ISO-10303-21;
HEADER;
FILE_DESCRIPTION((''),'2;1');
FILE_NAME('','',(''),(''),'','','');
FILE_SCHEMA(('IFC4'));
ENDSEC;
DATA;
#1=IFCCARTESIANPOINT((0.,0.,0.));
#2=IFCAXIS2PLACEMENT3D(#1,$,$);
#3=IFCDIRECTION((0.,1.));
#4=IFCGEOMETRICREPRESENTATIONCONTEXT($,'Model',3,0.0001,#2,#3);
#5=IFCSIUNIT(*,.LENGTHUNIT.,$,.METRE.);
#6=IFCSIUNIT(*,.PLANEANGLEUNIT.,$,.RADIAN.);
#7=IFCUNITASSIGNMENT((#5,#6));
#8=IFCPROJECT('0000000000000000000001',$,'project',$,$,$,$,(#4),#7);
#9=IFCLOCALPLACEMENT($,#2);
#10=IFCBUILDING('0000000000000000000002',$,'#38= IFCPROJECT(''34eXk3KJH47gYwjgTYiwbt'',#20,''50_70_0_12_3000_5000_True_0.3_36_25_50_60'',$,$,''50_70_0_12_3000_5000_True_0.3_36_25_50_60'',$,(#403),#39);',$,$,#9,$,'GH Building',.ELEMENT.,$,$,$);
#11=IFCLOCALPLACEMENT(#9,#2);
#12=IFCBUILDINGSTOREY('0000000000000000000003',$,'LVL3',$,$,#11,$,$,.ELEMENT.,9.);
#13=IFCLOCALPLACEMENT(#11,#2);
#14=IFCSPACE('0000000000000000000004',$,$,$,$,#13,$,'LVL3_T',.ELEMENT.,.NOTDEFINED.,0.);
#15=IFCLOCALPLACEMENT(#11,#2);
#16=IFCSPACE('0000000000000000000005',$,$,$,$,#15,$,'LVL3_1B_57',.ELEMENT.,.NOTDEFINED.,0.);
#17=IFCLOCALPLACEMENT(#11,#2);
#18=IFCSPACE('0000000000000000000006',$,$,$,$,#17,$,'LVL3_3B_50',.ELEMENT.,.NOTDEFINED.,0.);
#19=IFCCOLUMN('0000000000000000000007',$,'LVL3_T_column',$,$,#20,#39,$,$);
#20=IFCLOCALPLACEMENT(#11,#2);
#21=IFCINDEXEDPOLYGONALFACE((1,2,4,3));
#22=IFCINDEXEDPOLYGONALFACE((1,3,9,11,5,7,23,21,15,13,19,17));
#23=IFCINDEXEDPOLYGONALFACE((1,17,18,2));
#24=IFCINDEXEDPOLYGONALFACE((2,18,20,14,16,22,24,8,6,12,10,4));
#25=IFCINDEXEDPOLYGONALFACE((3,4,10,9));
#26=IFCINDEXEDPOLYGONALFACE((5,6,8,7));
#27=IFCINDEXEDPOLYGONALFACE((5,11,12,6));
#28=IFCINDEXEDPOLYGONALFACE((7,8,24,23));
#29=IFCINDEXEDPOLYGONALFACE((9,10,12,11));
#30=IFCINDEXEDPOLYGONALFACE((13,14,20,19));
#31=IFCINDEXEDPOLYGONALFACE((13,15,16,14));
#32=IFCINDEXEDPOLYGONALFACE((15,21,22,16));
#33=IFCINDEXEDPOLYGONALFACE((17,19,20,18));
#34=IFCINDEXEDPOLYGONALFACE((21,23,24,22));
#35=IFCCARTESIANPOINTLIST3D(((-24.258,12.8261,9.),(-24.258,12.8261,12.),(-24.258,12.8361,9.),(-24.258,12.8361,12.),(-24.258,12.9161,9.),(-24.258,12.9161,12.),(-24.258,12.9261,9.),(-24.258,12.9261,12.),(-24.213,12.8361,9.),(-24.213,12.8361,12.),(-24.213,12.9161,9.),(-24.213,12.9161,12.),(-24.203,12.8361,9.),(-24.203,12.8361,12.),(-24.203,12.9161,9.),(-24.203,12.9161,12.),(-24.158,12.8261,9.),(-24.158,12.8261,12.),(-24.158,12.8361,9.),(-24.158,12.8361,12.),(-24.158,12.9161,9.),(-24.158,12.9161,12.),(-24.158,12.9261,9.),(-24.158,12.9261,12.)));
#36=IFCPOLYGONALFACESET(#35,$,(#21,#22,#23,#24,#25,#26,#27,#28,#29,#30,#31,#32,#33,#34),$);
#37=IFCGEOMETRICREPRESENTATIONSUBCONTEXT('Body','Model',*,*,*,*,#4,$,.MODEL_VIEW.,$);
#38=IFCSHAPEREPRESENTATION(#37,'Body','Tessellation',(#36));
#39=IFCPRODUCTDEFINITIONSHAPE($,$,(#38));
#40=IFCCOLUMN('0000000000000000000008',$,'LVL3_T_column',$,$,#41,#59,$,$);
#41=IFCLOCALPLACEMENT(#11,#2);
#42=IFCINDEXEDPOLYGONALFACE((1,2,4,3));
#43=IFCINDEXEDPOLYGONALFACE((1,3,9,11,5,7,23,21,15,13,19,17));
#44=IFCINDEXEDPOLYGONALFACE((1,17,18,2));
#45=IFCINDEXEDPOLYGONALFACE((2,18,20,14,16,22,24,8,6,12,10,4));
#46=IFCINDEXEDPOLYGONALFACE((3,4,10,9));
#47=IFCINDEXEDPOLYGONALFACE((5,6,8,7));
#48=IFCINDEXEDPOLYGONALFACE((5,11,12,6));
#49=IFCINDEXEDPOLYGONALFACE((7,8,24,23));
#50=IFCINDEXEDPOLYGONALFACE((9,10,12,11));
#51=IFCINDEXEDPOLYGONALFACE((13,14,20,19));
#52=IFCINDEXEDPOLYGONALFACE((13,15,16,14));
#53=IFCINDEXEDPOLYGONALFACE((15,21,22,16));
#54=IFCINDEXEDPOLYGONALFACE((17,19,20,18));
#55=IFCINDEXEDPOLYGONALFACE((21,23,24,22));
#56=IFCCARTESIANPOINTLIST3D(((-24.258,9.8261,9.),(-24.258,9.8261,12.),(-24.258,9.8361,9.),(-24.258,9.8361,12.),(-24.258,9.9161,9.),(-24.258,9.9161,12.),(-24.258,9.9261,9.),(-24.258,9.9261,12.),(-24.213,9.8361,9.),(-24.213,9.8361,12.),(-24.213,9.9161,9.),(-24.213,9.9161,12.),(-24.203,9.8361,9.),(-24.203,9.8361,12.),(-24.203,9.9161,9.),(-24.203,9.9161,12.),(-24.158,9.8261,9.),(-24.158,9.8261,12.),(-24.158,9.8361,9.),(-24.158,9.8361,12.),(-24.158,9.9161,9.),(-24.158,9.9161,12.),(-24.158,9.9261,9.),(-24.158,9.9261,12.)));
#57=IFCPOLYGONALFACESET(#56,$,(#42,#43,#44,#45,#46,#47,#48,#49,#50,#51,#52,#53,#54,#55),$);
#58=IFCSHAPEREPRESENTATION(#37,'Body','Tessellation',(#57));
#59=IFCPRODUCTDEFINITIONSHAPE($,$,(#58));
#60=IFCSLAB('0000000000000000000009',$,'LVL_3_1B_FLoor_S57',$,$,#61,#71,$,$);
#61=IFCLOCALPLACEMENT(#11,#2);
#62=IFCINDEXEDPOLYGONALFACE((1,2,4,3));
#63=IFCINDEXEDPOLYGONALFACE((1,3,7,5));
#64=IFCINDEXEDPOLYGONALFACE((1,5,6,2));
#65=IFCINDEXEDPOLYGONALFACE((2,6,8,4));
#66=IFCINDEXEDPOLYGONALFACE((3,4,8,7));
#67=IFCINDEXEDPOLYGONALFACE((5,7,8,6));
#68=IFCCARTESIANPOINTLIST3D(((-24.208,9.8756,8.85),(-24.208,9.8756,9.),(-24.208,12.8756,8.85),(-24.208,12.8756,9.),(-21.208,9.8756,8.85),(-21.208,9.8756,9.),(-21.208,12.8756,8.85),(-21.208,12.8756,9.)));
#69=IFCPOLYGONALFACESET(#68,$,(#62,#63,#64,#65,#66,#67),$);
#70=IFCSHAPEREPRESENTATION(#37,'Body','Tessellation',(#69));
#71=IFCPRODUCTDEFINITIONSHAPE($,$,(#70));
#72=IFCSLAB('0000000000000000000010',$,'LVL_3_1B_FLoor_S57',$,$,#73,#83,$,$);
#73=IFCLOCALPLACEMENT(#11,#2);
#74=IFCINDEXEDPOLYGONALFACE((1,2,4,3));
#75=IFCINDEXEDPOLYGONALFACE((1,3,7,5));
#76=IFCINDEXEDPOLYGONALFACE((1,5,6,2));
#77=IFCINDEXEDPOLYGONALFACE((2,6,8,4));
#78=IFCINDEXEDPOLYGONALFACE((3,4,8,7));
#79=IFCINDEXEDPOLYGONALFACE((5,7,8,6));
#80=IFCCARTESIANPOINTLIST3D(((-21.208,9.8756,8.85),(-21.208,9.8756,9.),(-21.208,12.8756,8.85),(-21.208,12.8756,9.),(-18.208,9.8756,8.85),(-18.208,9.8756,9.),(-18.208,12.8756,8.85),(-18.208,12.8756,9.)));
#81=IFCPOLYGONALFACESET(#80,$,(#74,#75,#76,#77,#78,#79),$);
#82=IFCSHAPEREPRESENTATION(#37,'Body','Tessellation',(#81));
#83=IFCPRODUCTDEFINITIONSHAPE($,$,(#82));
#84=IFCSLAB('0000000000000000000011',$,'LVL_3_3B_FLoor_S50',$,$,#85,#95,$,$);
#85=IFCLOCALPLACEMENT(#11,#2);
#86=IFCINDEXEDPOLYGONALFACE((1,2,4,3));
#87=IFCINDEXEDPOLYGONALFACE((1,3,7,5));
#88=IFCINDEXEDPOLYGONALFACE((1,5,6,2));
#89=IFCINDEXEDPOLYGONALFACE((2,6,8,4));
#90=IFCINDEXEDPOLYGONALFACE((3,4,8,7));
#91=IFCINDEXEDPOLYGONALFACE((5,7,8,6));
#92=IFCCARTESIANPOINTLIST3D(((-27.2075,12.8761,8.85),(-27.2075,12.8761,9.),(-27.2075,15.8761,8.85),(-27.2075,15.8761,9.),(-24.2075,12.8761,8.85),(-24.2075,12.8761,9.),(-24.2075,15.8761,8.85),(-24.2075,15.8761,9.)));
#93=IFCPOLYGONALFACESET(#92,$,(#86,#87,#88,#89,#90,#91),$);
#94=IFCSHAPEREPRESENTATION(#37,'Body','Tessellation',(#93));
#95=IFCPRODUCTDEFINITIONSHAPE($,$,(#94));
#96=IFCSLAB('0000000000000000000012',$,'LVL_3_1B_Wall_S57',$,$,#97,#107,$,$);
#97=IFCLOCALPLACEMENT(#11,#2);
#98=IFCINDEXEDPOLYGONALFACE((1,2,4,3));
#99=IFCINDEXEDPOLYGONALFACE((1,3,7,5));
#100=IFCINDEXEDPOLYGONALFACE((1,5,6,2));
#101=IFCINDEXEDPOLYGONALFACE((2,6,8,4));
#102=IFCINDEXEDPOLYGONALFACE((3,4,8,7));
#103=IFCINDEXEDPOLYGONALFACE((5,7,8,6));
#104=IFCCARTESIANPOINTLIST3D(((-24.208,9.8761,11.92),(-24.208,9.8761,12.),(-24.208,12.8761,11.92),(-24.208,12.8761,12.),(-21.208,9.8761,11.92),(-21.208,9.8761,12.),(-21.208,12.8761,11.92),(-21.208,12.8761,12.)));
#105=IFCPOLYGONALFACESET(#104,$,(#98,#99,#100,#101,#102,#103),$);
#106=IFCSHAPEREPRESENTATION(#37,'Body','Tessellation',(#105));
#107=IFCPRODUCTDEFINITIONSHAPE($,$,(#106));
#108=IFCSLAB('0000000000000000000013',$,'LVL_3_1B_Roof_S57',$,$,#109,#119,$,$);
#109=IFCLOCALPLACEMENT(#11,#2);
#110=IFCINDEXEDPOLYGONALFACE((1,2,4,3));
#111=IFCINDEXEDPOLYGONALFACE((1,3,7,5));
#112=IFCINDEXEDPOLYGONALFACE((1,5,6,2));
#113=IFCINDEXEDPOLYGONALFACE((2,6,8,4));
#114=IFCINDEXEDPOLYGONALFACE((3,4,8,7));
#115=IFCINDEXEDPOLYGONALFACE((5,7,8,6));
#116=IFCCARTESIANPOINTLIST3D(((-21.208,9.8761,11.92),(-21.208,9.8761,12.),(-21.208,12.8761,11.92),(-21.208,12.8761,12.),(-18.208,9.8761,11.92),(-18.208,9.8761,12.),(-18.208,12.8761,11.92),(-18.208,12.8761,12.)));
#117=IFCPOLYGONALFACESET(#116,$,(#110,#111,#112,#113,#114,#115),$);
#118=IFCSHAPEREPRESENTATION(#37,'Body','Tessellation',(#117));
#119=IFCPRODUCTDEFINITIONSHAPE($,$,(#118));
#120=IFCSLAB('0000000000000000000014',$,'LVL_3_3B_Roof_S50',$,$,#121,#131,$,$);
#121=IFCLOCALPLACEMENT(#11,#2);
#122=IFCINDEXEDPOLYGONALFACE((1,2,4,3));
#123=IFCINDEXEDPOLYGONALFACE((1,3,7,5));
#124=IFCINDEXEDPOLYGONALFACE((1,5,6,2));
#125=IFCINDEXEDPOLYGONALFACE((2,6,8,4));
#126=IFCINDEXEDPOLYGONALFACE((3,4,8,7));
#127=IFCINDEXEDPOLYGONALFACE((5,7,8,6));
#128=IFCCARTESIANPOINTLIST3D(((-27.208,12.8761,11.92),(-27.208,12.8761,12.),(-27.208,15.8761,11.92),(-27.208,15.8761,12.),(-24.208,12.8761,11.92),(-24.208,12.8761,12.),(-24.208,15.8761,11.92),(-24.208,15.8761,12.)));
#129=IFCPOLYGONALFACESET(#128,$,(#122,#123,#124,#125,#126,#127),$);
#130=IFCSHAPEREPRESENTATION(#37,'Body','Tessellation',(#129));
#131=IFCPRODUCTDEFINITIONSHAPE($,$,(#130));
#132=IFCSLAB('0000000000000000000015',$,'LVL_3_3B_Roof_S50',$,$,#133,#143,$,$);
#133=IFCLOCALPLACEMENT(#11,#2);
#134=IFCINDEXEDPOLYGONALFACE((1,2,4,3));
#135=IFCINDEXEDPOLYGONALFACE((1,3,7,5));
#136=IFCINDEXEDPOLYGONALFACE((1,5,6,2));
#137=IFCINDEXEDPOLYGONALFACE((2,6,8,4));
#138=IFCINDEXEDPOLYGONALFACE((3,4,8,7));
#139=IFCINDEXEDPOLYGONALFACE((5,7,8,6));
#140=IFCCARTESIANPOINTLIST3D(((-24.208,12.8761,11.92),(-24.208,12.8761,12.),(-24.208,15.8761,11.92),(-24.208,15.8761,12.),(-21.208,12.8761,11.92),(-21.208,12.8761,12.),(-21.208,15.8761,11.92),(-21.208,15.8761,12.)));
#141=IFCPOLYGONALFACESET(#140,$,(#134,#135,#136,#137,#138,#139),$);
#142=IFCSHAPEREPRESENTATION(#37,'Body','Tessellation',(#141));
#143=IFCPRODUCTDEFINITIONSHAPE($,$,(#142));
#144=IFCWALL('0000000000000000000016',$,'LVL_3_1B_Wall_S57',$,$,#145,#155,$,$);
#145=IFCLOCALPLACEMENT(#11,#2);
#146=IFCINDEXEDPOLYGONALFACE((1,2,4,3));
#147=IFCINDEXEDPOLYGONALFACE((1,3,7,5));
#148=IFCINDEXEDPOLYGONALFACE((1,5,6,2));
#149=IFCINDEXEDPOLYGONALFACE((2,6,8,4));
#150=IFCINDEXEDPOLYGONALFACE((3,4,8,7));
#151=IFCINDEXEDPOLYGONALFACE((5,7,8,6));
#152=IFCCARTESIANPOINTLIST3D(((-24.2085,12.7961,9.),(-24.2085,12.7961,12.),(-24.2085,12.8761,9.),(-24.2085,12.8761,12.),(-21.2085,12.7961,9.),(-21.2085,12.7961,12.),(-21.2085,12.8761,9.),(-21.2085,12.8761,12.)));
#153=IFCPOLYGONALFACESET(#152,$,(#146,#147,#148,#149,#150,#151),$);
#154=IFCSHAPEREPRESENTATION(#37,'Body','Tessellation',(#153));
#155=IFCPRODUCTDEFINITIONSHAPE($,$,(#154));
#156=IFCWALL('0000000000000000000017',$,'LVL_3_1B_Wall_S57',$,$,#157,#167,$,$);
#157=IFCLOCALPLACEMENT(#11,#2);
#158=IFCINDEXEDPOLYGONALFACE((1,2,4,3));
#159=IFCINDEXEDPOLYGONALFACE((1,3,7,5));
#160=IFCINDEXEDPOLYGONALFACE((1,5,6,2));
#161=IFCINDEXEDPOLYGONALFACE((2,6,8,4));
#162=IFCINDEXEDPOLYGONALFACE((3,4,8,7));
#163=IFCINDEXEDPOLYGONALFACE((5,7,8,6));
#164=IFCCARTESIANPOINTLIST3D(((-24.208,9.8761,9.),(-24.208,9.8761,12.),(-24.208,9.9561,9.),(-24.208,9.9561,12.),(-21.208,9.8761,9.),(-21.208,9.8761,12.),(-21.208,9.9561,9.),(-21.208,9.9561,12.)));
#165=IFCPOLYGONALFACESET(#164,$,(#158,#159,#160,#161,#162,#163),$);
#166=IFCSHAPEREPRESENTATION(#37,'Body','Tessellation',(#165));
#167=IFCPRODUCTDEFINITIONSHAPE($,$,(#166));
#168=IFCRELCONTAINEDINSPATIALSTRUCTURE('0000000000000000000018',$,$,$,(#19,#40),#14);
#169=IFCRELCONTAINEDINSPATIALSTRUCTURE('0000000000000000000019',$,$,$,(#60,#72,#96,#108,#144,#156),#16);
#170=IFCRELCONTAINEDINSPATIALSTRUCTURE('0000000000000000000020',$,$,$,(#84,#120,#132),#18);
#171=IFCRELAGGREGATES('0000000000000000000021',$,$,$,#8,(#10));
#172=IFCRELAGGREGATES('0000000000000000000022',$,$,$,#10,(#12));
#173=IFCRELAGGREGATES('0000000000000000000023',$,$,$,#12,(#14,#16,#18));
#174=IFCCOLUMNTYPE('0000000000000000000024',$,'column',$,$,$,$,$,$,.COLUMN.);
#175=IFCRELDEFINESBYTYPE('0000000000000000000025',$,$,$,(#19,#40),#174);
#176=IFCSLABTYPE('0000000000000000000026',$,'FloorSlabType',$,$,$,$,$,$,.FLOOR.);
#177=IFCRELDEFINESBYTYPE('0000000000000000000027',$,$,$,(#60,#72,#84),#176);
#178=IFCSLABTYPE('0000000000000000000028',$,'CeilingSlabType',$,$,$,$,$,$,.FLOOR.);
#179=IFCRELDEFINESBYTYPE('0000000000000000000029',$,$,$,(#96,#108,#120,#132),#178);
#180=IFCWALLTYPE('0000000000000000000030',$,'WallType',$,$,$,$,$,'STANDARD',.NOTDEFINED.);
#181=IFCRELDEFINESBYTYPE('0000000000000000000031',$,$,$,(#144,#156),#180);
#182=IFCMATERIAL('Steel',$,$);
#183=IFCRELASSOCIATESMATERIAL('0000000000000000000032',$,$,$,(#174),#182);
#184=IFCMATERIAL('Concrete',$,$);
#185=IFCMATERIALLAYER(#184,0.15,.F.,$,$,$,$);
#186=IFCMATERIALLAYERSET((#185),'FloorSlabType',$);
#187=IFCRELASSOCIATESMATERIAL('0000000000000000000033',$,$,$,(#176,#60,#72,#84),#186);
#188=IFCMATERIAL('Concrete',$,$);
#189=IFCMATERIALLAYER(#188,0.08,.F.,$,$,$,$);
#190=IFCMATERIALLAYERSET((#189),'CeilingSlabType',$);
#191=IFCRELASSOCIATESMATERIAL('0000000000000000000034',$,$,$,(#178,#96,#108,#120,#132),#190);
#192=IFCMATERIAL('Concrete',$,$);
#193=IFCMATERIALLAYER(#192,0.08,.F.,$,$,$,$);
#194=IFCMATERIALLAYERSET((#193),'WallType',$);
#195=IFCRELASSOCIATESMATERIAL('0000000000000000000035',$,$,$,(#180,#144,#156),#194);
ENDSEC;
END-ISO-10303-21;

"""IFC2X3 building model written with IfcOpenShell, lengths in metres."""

from ifc_helpers import new_model, si_unit, direction, frame, frame_2d, origin, origin_2d, place, context, subcontext, project, spatial, rectangle, i_section, extrude, material, layer, layer_set, layer_usage, type_object, element, save


model = new_model("IFC2X3")

# Units and contexts
model_context = context("Model", 3, precision=0.0001, world=origin(), true_north=direction((0.0, 1.0)))
body_context = subcontext(model_context, "Body", "Model", "MODEL_VIEW")
ifc_project = project(units=[si_unit("LENGTHUNIT", "METRE"), si_unit("PLANEANGLEUNIT", "RADIAN")], contexts=[model_context])

# Building, storey, space
building_placement = place(None, origin())
building = spatial("IfcBuilding", under=ifc_project, at=building_placement, Name="#38= IFCPROJECT('34eXk3KJH47gYwjgTYiwbt',#20,'50_70_0_12_3000_5000_True_0.3_36_25_50_60',$,$,'50_70_0_12_3000_5000_True_0.3_36_25_50_60',$,(#403),#39);", LongName="GH Building", CompositionType="ELEMENT")
storey_placement = place(building_placement, origin())
storey = spatial("IfcBuildingStorey", under=building, at=storey_placement, Name="LVL3", CompositionType="ELEMENT", Elevation=9.0)
space_1_placement = place(storey_placement, origin())
space_1 = spatial("IfcSpace", under=storey, at=space_1_placement, LongName="LVL3_T", CompositionType="ELEMENT", InteriorOrExteriorSpace="NOTDEFINED", ElevationWithFlooring=0.0)

# Columns
ifc_material_1 = material(Name="Steel")
column_type = type_object("IfcColumnType", Name="column", PredefinedType="COLUMN", material=ifc_material_1)
for number, where, name in (
    (1, (-24.208, 12.8761, 9.0), "LVL3_T_column"),
    (2, (-24.208, 9.8761, 9.0), "LVL3_T_column"),
):
    element("IfcColumn", number, at=place(space_1_placement, frame(where)), inside=space_1, type_object=column_type, Name=name, context=body_context, shape_type="SweptSolid", body=[
        extrude(i_section(OverallWidth=0.1, OverallDepth=0.1, WebThickness=0.01, FlangeThickness=0.01, at=origin_2d()), origin(), (0.0, 0.0, 1.0), 3.0),
    ])

# Shared definitions
space_2_placement = place(storey_placement, origin())
space_2 = spatial("IfcSpace", under=storey, at=space_2_placement, LongName="LVL3_1B_57", CompositionType="ELEMENT", InteriorOrExteriorSpace="NOTDEFINED", ElevationWithFlooring=0.0)

# Slabs
ifc_material_2 = material(Name="Concrete")
ifc_layer_1 = layer(ifc_material_2, 0.15, ventilated=False)
ifc_layer_set_1 = layer_set([ifc_layer_1], Name="FloorSlabType")
ifc_layer_usage_1 = layer_usage(ifc_layer_set_1, "AXIS3", "NEGATIVE", -0.15)
slab_type_1 = type_object("IfcSlabType", Name="FloorSlabType", PredefinedType="FLOOR", material=ifc_layer_set_1)
slab_1_placement = place(space_2_placement, frame((-24.208, 9.8756, 8.85)))
element("IfcSlab", 3, at=slab_1_placement, inside=space_2, type_object=slab_type_1, material=ifc_layer_usage_1, Name="LVL_3_1B_FLoor_S57", context=body_context, shape_type="SweptSolid", body=[
    extrude(rectangle(XDim=3.0, YDim=3.0, at=frame_2d((1.5, 1.5))), origin(), (0.0, 0.0, 1.0), 0.15),
])
ifc_layer_usage_2 = layer_usage(ifc_layer_set_1, "AXIS3", "NEGATIVE", -0.15)
slab_2_placement = place(space_2_placement, frame((-21.208, 9.8756, 8.85)))
element("IfcSlab", 4, at=slab_2_placement, inside=space_2, type_object=slab_type_1, material=ifc_layer_usage_2, Name="LVL_3_1B_FLoor_S57", context=body_context, shape_type="SweptSolid", body=[
    extrude(rectangle(XDim=3.0, YDim=3.0, at=frame_2d((1.5, 1.5))), origin(), (0.0, 0.0, 1.0), 0.15),
])

# Shared definitions
space_3_placement = place(storey_placement, origin())
space_3 = spatial("IfcSpace", under=storey, at=space_3_placement, LongName="LVL3_3B_50", CompositionType="ELEMENT", InteriorOrExteriorSpace="NOTDEFINED", ElevationWithFlooring=0.0)

# Slabs
ifc_layer_usage_3 = layer_usage(ifc_layer_set_1, "AXIS3", "NEGATIVE", -0.15)
slab_3_placement = place(space_3_placement, frame((-24.2075, 12.8761, 8.85), z_axis=(0.0, 0.0, 1.0), x_axis=(0.0, 1.0, 0.0)))
element("IfcSlab", 5, at=slab_3_placement, inside=space_3, type_object=slab_type_1, material=ifc_layer_usage_3, Name="LVL_3_3B_FLoor_S50", context=body_context, shape_type="SweptSolid", body=[
    extrude(rectangle(XDim=3.0, YDim=3.0, at=frame_2d((1.5, 1.5))), origin(), (0.0, 0.0, 1.0), 0.15),
])
ifc_material_3 = material(Name="Concrete")
ifc_layer_2 = layer(ifc_material_3, 0.08, ventilated=False)
ifc_layer_set_2 = layer_set([ifc_layer_2], Name="CeilingSlabType")
ifc_layer_usage_4 = layer_usage(ifc_layer_set_2, "AXIS3", "NEGATIVE", -0.08)
slab_type_2 = type_object("IfcSlabType", Name="CeilingSlabType", PredefinedType="FLOOR", material=ifc_layer_set_2)
slab_4_placement = place(space_2_placement, frame((-24.208, 9.8761, 11.92)))
element("IfcSlab", 6, at=slab_4_placement, inside=space_2, type_object=slab_type_2, material=ifc_layer_usage_4, Name="LVL_3_1B_Wall_S57", context=body_context, shape_type="SweptSolid", body=[
    extrude(rectangle(XDim=3.0, YDim=3.0, at=frame_2d((1.5, 1.5))), origin(), (0.0, 0.0, 1.0), 0.08),
])
ifc_layer_usage_5 = layer_usage(ifc_layer_set_2, "AXIS3", "NEGATIVE", -0.08)
slab_5_placement = place(space_2_placement, frame((-21.208, 9.8761, 11.92)))
element("IfcSlab", 7, at=slab_5_placement, inside=space_2, type_object=slab_type_2, material=ifc_layer_usage_5, Name="LVL_3_1B_Roof_S57", context=body_context, shape_type="SweptSolid", body=[
    extrude(rectangle(XDim=3.0, YDim=3.0, at=frame_2d((1.5, 1.5))), origin(), (0.0, 0.0, 1.0), 0.08),
])
ifc_layer_usage_6 = layer_usage(ifc_layer_set_2, "AXIS3", "NEGATIVE", -0.08)
slab_6_placement = place(space_3_placement, frame((-24.208, 12.8761, 11.92), z_axis=(0.0, 0.0, 1.0), x_axis=(0.0, 1.0, 0.0)))
element("IfcSlab", 8, at=slab_6_placement, inside=space_3, type_object=slab_type_2, material=ifc_layer_usage_6, Name="LVL_3_3B_Roof_S50", context=body_context, shape_type="SweptSolid", body=[
    extrude(rectangle(XDim=3.0, YDim=3.0, at=frame_2d((1.5, 1.5))), origin(), (0.0, 0.0, 1.0), 0.08),
])
ifc_layer_usage_7 = layer_usage(ifc_layer_set_2, "AXIS3", "NEGATIVE", -0.08)
slab_7_placement = place(space_3_placement, frame((-21.208, 12.8761, 11.92), z_axis=(0.0, 0.0, 1.0), x_axis=(0.0, 1.0, 0.0)))
element("IfcSlab", 9, at=slab_7_placement, inside=space_3, type_object=slab_type_2, material=ifc_layer_usage_7, Name="LVL_3_3B_Roof_S50", context=body_context, shape_type="SweptSolid", body=[
    extrude(rectangle(XDim=3.0, YDim=3.0, at=frame_2d((1.5, 1.5))), origin(), (0.0, 0.0, 1.0), 0.08),
])

# Shared definitions
ifc_material_4 = material(Name="Concrete")
ifc_layer_3 = layer(ifc_material_4, 0.08, ventilated=False)
ifc_layer_set_3 = layer_set([ifc_layer_3], Name="WallType")
wall_type = type_object("IfcWallType", Name="WallType", ElementType="STANDARD", PredefinedType="NOTDEFINED", material=ifc_layer_set_3)

# Walls
ifc_layer_usage_8 = layer_usage(ifc_layer_set_3, "AXIS2", "NEGATIVE", 0.0)
wall_1_placement = place(space_2_placement, frame((-24.2085, 12.8761, 9.0)))
element("IfcWall", 10, at=wall_1_placement, inside=space_2, type_object=wall_type, material=ifc_layer_usage_8, Name="LVL_3_1B_Wall_S57", context=body_context, shape_type="SweptSolid", body=[
    extrude(rectangle(XDim=3.0, YDim=0.08, at=frame_2d((1.5, -0.04))), origin(), (0.0, 0.0, 1.0), 3.0),
])
ifc_layer_usage_9 = layer_usage(ifc_layer_set_3, "AXIS2", "NEGATIVE", 0.0)
wall_2_placement = place(space_2_placement, frame((-21.208, 9.8761, 9.0), z_axis=(0.0, 0.0, 1.0), x_axis=(-1.0, 0.0, 0.0)))
element("IfcWall", 11, at=wall_2_placement, inside=space_2, type_object=wall_type, material=ifc_layer_usage_9, Name="LVL_3_1B_Wall_S57", context=body_context, shape_type="SweptSolid", body=[
    extrude(rectangle(XDim=3.0, YDim=0.08, at=frame_2d((1.5, -0.04))), origin(), (0.0, 0.0, 1.0), 3.0),
])

save(model, "model.ifc")
